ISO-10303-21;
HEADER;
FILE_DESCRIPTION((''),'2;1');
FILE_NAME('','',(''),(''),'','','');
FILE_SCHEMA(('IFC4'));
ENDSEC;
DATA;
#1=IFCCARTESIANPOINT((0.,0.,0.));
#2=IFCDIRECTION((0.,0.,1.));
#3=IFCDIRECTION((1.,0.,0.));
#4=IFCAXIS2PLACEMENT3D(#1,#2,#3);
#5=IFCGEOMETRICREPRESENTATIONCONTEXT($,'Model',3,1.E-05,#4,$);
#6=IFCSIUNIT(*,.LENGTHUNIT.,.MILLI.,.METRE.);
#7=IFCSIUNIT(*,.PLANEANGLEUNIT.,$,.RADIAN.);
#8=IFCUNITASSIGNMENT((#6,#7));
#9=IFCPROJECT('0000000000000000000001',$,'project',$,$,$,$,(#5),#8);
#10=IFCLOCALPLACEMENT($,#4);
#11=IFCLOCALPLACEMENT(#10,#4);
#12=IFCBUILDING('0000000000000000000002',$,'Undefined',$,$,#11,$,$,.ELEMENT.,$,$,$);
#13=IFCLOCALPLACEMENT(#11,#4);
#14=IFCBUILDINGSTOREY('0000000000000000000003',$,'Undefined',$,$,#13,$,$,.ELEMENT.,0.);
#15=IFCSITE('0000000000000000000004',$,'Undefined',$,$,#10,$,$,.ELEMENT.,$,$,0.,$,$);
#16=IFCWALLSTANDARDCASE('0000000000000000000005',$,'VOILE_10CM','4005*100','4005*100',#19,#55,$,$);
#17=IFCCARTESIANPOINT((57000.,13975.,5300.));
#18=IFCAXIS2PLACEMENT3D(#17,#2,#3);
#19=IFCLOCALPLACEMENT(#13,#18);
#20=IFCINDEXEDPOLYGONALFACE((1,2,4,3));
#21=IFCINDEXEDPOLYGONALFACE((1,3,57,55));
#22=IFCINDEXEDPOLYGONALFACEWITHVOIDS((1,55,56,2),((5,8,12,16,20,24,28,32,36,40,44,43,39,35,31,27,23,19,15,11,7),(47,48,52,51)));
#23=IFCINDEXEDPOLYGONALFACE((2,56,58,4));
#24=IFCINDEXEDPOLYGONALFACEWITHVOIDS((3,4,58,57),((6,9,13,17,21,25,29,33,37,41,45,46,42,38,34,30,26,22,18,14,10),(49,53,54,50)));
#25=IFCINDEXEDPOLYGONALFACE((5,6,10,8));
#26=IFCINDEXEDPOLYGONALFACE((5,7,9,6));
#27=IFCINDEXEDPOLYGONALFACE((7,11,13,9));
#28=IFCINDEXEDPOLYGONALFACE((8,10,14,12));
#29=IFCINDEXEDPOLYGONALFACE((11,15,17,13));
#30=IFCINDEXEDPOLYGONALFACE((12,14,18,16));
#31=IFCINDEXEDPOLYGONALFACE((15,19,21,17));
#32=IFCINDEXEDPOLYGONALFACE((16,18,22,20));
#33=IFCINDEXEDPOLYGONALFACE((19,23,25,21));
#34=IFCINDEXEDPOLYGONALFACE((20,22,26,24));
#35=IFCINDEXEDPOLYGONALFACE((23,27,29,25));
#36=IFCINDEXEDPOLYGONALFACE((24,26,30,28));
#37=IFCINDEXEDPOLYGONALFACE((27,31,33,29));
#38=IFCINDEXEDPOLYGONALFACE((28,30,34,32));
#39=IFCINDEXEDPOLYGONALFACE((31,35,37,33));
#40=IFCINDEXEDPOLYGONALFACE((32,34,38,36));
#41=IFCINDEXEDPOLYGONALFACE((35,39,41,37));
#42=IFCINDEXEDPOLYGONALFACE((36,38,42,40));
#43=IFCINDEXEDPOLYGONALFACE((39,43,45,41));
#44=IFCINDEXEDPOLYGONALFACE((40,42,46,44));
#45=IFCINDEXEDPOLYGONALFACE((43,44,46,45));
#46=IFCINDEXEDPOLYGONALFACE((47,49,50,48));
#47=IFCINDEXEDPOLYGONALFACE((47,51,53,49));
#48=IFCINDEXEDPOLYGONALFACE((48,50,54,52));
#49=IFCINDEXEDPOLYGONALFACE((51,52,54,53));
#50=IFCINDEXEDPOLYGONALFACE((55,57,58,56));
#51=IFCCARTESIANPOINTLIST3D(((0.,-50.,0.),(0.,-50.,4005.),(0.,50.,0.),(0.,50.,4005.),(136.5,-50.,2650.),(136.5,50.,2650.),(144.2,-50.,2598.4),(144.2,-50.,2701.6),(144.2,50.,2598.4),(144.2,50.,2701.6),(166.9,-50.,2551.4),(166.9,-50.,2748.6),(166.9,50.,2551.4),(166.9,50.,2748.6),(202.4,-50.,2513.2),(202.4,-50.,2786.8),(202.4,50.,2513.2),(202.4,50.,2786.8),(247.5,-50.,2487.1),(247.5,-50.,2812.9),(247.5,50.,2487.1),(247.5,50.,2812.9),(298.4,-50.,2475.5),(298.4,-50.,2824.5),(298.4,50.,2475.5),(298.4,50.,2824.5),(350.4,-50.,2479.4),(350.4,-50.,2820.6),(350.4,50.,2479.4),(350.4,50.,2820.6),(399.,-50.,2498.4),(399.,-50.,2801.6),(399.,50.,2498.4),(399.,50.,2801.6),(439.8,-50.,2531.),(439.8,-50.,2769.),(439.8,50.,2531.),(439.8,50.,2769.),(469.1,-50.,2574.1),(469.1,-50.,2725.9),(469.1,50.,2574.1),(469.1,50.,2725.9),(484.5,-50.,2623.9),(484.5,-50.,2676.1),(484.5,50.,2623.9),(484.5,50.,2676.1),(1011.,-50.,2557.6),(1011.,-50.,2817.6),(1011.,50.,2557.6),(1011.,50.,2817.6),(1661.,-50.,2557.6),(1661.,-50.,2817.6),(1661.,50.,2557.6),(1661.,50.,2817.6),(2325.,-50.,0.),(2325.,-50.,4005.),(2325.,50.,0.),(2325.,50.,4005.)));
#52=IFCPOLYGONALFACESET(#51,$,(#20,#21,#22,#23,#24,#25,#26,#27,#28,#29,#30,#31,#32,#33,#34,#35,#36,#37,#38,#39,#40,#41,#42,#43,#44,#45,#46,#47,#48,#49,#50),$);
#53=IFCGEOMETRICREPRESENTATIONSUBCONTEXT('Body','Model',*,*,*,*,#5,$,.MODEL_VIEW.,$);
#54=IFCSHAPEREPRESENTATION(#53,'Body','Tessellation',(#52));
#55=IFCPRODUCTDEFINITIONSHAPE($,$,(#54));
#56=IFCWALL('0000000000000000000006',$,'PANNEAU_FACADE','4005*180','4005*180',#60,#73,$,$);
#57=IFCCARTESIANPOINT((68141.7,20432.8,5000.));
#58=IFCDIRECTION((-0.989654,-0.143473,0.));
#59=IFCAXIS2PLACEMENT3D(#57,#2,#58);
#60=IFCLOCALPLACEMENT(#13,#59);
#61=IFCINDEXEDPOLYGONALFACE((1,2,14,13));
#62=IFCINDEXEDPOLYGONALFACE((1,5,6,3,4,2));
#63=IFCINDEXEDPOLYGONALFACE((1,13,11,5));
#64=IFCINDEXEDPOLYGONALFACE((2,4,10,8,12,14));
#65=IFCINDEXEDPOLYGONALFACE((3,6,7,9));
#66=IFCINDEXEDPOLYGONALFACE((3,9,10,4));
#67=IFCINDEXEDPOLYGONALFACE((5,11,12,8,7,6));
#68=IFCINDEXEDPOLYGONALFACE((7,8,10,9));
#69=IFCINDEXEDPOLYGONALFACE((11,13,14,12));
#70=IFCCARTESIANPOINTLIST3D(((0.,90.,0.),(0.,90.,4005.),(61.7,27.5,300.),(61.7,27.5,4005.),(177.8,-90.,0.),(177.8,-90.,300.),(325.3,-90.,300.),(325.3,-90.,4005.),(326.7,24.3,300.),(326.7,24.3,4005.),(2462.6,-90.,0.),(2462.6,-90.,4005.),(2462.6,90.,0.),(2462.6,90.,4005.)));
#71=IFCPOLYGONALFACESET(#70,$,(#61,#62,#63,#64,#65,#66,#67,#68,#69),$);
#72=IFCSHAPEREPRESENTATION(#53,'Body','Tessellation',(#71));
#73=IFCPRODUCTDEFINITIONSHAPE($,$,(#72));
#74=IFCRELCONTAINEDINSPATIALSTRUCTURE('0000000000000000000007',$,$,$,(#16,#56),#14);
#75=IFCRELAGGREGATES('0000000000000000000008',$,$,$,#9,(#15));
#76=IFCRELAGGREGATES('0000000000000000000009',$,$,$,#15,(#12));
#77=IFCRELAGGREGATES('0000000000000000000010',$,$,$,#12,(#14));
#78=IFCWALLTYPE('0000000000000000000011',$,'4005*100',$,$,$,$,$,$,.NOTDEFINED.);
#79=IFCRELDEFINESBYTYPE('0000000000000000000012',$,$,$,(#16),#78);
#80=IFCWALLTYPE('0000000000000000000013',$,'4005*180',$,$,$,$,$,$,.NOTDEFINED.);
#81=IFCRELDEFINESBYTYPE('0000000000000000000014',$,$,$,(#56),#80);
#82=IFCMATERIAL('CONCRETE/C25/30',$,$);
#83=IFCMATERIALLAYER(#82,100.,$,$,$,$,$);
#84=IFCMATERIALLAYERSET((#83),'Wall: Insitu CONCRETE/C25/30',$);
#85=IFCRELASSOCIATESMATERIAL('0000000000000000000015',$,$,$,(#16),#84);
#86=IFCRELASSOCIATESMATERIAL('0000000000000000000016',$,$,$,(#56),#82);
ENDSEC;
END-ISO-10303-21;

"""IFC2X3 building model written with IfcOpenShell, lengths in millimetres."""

from ifc_helpers import new_model, si_unit, frame, frame_2d, origin_with_axes, origin_2d_with_axis, place, context, subcontext, project, spatial, rectangle, circle, extrude, boolean, halfspace, material, layer, layer_set, layer_usage, type_object, element, save


model = new_model("IFC2X3")

# Units and contexts
model_context = context("Model", 3, precision=1e-05, world=origin_with_axes())
body_context = subcontext(model_context, "Body", "Model", "MODEL_VIEW")
ifc_project = project(units=[si_unit("LENGTHUNIT", "METRE", prefix="MILLI"), si_unit("PLANEANGLEUNIT", "RADIAN")], contexts=[model_context])

# Site, building, storey
site_placement = place(None, origin_with_axes())
site = spatial("IfcSite", under=ifc_project, at=site_placement, Name="Undefined", CompositionType="ELEMENT", RefElevation=0.0)
building_placement = place(site_placement, origin_with_axes())
building = spatial("IfcBuilding", under=site, at=building_placement, Name="Undefined", CompositionType="ELEMENT")
storey_placement = place(building_placement, origin_with_axes())
storey = spatial("IfcBuildingStorey", under=building, at=storey_placement, Name="Undefined", CompositionType="ELEMENT", Elevation=0.0)

# Shared definitions
ifc_material_1 = material(Name="CONCRETE/C25/30")

# Walls
ifc_layer_1 = layer(ifc_material_1, 100.0)
ifc_layer_set_1 = layer_set([ifc_layer_1], Name="Wall: Insitu CONCRETE/C25/30")
ifc_layer_usage_1 = layer_usage(ifc_layer_set_1, "AXIS2", "POSITIVE", -50.0)
wall_type_1 = type_object("IfcWallType", Name="4005*100", PredefinedType="NOTDEFINED")
wall_1_placement = place(storey_placement, frame((57000.0, 13975.0, 5300.0), z_axis=(0.0, 0.0, 1.0), x_axis=(1.0, 0.0, 0.0)))
element("IfcWallStandardCase", 1, at=wall_1_placement, inside=storey, type_object=wall_type_1, material=ifc_layer_usage_1, Name="VOILE_10CM", Description="4005*100", ObjectType="4005*100", context=body_context, shape_type="CSG", body=[
    boolean("DIFFERENCE", boolean("DIFFERENCE", extrude(rectangle(XDim=2325.0, YDim=100.0, at=frame_2d((0.0, 1162.5), x_axis=(0.0, -1.0))), frame((0.0, 0.0, 0.0), z_axis=(0.0, 0.0, 1.0), x_axis=(0.0, -1.0, 0.0)), (0.0, 0.0, 1.0), 4005.0), extrude(circle(Radius=175.0, at=origin_2d_with_axis()), frame((311.5, -60.0, 2650.0), z_axis=(0.0, 1.0, 0.0), x_axis=(-1.0, 0.0, 0.0)), (0.0, 0.0, 1.0), 120.0)), extrude(rectangle(XDim=650.0, YDim=260.0, at=origin_2d_with_axis()), frame((1336.0, -60.0, 2687.6), z_axis=(0.0, 1.0, 0.0), x_axis=(-1.0, 0.0, 0.0)), (0.0, 0.0, 1.0), 120.0)),
])
wall_type_2 = type_object("IfcWallType", Name="4005*180", PredefinedType="NOTDEFINED")
wall_2_placement = place(storey_placement, frame((68141.7, 20432.8, 5000.0), z_axis=(0.0, 0.0, 1.0), x_axis=(-0.989654, -0.143473, 0.0)))
element("IfcWall", 2, at=wall_2_placement, inside=storey, type_object=wall_type_2, material=ifc_material_1, Name="PANNEAU_FACADE", Description="4005*180", ObjectType="4005*180", context=body_context, shape_type="CSG", body=[
    boolean("DIFFERENCE", boolean("DIFFERENCE", extrude(rectangle(XDim=2673.7, YDim=180.0, at=frame_2d((0.0, 1125.8), x_axis=(0.0, -1.0))), frame((0.0, 0.0, 0.0), z_axis=(0.0, 0.0, 1.0), x_axis=(0.0, -1.0, 0.0)), (0.0, 0.0, 1.0), 4005.0), extrude(rectangle(XDim=265.0, YDim=265.0, at=origin_2d_with_axis()), frame((192.6, -106.6, 4005.0), z_axis=(0.0, 0.0, -1.0), x_axis=(-0.012306, -0.999924, 0.0)), (0.0, 0.0, 1.0), 3705.0)), halfspace(frame((0.0, 90.0, 2002.5), z_axis=(-0.711444, -0.702742, 0.0), x_axis=(0.0, 0.0, 1.0)), False)),
])

save(model, "model.ifc")
